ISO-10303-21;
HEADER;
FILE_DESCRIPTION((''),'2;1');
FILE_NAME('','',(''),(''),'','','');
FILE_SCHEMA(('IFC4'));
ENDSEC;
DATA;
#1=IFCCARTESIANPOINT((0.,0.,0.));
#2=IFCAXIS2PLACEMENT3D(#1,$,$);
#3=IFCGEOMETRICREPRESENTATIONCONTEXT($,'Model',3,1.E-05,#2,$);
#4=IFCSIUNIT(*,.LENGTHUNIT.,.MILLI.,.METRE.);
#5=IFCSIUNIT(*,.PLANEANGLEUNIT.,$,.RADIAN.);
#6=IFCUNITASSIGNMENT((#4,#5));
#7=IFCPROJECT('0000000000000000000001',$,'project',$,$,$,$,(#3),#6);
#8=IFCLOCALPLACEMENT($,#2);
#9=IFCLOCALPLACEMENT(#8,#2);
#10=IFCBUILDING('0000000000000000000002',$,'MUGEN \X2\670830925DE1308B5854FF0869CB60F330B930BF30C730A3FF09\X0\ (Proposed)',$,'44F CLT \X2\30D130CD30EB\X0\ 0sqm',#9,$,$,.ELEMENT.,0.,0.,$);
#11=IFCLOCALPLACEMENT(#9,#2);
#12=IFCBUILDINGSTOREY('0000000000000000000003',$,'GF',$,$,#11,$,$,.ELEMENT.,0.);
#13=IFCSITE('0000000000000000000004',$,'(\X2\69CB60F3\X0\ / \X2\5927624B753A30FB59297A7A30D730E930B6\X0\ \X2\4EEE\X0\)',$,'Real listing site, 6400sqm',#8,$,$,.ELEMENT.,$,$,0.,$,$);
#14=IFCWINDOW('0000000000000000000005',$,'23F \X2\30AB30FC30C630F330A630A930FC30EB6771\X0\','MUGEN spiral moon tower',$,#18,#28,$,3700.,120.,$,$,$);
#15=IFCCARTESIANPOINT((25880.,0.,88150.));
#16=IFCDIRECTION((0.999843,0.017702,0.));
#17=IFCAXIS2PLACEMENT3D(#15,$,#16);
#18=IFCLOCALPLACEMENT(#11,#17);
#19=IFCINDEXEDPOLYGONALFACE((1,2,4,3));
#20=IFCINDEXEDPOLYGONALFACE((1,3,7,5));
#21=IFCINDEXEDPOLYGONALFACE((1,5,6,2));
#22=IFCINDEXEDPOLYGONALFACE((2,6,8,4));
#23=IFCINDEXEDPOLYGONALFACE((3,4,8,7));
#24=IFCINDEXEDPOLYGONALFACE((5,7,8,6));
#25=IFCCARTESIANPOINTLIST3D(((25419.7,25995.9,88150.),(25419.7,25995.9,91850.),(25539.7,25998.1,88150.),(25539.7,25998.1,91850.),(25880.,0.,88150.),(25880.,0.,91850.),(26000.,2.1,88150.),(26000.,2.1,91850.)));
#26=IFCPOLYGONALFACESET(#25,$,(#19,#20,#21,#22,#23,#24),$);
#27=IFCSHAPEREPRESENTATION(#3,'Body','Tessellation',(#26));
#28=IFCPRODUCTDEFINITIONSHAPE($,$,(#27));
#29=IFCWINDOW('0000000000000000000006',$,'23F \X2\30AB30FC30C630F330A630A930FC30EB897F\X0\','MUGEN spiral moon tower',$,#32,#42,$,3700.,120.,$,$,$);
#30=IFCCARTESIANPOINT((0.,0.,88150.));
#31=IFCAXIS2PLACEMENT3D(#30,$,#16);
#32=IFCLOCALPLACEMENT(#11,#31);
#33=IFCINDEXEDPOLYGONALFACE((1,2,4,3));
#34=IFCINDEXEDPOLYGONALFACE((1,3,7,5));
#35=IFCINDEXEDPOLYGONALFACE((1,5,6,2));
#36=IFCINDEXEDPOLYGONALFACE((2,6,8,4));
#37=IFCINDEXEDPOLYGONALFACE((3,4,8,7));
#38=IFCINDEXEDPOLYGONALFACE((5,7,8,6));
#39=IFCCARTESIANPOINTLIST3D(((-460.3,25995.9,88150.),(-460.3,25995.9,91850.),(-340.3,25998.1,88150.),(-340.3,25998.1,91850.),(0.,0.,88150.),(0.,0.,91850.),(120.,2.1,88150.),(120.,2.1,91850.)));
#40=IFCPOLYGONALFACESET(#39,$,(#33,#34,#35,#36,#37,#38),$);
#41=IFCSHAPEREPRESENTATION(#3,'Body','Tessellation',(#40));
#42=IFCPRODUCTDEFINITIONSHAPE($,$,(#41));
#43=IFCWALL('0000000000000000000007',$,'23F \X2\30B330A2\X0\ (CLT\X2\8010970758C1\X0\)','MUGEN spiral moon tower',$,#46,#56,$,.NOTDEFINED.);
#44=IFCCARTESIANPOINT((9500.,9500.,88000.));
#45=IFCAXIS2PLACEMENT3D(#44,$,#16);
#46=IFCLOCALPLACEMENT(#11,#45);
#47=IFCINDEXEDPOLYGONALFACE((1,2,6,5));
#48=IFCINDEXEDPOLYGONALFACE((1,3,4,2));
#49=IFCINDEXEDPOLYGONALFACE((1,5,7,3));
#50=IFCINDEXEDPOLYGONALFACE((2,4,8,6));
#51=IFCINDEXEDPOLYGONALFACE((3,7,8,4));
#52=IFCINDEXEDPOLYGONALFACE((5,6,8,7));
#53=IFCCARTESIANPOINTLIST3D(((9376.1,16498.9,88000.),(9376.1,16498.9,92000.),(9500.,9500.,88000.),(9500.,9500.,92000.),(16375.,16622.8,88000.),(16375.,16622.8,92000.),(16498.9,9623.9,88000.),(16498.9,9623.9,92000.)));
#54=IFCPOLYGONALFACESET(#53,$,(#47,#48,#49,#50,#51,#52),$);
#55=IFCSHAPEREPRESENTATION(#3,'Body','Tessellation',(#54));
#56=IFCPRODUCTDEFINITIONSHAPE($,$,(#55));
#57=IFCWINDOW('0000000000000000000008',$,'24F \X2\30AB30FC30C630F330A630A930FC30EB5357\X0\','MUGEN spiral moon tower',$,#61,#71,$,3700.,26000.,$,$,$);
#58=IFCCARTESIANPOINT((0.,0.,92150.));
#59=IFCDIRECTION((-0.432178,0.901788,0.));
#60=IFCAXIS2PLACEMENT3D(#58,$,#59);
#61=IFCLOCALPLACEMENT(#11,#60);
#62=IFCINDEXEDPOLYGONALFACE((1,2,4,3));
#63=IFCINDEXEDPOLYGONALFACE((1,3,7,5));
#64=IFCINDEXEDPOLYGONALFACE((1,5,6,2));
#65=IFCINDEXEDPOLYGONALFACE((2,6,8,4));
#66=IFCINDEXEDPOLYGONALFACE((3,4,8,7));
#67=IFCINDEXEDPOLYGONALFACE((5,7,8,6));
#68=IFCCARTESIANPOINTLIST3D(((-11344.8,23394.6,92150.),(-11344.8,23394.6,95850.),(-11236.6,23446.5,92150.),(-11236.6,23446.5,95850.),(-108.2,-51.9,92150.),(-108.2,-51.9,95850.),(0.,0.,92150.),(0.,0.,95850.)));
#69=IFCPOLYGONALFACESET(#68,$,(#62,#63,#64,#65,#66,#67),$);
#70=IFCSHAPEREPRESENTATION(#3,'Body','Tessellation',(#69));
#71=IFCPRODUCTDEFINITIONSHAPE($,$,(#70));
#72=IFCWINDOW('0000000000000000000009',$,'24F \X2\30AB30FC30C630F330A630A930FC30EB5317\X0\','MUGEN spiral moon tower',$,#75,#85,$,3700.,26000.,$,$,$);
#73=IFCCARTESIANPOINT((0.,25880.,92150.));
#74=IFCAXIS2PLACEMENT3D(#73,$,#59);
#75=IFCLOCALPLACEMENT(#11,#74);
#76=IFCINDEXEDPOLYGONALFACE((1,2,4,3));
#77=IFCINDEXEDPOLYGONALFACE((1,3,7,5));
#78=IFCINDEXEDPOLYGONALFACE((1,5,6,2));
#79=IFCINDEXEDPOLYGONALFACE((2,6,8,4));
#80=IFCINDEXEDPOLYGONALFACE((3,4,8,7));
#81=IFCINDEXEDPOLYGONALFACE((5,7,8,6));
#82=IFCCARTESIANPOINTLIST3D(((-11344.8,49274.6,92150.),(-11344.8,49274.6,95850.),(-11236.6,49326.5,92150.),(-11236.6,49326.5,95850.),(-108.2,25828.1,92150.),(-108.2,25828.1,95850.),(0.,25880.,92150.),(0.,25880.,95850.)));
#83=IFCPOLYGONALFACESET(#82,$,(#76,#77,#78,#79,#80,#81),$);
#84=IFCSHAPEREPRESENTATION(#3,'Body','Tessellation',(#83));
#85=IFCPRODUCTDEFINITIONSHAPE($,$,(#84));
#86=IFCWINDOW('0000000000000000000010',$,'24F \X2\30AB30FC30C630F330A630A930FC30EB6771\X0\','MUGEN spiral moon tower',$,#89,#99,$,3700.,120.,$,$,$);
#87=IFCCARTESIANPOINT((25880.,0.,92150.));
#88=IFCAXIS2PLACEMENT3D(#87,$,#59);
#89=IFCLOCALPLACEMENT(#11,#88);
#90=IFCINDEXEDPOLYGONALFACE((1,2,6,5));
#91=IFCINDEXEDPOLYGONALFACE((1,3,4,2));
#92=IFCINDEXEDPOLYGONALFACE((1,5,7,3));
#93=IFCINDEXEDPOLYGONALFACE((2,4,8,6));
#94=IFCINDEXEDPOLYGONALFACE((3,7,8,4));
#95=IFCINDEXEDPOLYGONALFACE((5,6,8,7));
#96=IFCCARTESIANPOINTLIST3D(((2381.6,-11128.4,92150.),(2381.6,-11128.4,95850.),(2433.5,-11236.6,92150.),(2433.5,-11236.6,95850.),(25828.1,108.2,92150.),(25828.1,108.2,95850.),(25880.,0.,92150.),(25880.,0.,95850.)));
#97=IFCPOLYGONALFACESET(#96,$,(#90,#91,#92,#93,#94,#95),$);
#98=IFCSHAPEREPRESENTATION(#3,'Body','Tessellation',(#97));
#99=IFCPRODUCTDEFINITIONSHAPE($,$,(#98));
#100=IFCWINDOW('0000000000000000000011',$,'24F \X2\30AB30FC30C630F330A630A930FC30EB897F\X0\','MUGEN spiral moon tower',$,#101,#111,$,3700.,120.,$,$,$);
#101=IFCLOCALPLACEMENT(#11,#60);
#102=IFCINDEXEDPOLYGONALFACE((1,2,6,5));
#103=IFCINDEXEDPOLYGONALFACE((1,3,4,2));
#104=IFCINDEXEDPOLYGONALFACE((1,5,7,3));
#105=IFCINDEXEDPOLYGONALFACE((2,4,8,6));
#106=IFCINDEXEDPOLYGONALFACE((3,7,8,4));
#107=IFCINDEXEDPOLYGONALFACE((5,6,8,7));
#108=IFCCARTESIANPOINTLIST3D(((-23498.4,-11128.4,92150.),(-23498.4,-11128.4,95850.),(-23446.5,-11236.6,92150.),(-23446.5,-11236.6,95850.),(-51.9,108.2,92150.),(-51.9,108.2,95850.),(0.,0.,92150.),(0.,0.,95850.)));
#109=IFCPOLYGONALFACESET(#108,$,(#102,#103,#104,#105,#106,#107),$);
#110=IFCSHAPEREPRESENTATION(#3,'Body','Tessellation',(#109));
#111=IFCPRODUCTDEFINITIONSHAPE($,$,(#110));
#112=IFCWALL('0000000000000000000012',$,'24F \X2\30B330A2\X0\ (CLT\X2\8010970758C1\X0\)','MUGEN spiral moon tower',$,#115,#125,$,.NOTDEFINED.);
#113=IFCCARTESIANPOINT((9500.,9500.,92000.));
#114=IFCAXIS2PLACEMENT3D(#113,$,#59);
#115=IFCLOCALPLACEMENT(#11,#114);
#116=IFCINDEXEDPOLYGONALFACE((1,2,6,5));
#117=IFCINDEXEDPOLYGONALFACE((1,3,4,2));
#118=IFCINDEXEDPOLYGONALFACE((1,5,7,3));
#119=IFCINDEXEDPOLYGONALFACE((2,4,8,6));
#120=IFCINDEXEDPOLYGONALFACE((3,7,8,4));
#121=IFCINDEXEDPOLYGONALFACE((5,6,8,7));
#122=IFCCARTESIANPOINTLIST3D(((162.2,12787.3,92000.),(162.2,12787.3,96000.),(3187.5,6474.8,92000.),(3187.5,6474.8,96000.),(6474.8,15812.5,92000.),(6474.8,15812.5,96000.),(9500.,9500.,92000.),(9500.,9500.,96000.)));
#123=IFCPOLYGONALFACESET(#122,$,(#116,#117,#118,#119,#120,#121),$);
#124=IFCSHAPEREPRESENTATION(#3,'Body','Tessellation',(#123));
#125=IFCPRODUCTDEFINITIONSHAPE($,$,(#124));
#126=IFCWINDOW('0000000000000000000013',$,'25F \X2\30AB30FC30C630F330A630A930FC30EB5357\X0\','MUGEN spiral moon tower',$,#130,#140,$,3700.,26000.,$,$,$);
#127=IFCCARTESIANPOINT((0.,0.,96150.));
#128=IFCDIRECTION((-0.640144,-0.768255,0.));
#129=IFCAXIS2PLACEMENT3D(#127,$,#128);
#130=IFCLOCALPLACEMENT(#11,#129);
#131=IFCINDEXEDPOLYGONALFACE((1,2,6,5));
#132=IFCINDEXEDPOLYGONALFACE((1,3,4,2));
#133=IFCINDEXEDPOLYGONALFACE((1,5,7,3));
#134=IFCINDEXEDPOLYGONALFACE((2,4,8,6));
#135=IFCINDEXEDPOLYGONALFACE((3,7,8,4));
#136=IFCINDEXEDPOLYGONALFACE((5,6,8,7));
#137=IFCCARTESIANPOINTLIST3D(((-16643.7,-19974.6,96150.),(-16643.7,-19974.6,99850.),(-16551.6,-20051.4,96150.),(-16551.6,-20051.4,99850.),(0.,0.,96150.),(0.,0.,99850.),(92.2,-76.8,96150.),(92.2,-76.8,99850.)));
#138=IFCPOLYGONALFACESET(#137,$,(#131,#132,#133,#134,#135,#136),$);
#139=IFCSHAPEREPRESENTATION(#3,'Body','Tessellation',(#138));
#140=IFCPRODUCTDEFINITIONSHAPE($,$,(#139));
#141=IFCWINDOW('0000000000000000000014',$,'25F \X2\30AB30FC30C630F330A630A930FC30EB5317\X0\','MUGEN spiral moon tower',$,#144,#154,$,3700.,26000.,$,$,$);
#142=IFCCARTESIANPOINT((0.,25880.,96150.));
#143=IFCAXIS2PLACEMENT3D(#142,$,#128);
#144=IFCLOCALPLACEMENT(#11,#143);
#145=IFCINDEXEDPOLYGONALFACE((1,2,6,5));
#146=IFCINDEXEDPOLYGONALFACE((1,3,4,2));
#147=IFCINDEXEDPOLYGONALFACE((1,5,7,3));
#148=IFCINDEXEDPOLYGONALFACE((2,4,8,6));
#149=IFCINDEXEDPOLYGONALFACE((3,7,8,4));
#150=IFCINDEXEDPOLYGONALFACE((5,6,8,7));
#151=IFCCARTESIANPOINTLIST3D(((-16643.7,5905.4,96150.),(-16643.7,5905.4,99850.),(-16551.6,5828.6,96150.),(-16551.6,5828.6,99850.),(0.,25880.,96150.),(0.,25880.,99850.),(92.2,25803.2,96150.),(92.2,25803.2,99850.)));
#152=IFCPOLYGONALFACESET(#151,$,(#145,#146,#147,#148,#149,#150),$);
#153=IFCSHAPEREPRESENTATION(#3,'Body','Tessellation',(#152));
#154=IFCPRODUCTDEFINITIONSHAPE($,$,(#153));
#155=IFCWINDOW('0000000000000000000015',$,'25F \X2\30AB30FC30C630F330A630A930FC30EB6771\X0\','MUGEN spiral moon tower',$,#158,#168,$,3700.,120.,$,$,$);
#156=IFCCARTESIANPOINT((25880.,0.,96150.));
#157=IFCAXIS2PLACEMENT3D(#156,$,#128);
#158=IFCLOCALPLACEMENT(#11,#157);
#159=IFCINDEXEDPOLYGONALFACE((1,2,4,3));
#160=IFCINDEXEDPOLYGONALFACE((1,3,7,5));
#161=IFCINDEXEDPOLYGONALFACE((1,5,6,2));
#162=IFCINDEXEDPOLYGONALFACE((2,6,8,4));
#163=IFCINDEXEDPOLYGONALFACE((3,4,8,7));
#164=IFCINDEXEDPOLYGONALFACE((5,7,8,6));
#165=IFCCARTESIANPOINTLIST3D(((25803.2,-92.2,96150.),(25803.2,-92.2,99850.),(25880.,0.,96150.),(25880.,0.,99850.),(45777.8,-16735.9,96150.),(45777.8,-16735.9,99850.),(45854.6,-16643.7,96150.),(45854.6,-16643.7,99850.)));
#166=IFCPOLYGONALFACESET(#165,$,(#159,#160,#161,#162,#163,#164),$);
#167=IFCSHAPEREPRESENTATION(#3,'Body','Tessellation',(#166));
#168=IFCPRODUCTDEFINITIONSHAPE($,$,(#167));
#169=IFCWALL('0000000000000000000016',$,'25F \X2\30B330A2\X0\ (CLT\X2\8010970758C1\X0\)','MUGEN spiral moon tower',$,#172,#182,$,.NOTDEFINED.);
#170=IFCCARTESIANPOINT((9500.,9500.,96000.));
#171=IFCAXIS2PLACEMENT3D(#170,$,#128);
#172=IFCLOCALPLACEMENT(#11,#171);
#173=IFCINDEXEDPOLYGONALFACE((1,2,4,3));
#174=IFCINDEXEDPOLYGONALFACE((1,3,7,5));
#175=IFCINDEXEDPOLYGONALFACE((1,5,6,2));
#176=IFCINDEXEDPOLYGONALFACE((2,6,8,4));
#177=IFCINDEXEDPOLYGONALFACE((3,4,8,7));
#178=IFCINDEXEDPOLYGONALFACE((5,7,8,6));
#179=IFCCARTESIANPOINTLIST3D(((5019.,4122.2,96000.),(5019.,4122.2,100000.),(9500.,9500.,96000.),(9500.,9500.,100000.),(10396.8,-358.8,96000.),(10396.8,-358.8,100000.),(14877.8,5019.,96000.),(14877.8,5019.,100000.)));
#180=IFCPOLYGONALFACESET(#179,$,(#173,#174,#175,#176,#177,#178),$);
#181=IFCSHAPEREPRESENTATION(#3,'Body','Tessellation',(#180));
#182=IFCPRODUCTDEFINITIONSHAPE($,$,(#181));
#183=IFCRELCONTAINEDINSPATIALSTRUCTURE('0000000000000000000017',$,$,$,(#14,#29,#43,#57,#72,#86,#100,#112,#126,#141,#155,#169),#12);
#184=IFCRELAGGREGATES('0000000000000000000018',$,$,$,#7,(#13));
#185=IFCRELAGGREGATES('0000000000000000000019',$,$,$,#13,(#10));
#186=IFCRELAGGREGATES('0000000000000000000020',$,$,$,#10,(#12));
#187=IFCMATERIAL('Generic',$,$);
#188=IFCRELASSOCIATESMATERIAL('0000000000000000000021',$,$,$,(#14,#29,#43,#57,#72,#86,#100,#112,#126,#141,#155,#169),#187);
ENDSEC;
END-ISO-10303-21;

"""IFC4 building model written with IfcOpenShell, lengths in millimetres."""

from ifc_helpers import new_model, si_unit, frame, frame_2d, origin, place, context, project, spatial, rectangle, extrude, material, element, save


model = new_model("IFC4")

# Units and contexts
model_context = context("Model", 3, precision=1e-05, world=origin())
ifc_project = project(units=[si_unit("LENGTHUNIT", "METRE", prefix="MILLI"), si_unit("PLANEANGLEUNIT", "RADIAN")], contexts=[model_context])

# Site, building, storey
site_placement = place(None, origin())
site = spatial("IfcSite", under=ifc_project, at=site_placement, Name="(構想 / 大手町・天空プラザ 仮)", ObjectType="Real listing site, 6400sqm", CompositionType="ELEMENT", RefElevation=0.0)
building_placement = place(site_placement, origin())
building = spatial("IfcBuilding", under=site, at=building_placement, Name="MUGEN 月を巡る塔（構想スタディ） (Proposed)", ObjectType="44F CLT パネル 0sqm", CompositionType="ELEMENT", ElevationOfRefHeight=0.0, ElevationOfTerrain=0.0)
storey_placement = place(building_placement, origin())
storey = spatial("IfcBuildingStorey", under=building, at=storey_placement, Name="GF", CompositionType="ELEMENT", Elevation=0.0)

# Shared definitions
ifc_material = material(Name="Generic")

# Windows
window_1_placement = place(storey_placement, frame((25880.0, 0.0, 88150.0), x_axis=(0.999843, 0.017702, 0.0)))
element("IfcWindow", 1, at=window_1_placement, inside=storey, material=ifc_material, Name="23F カーテンウォール東", Description="MUGEN spiral moon tower", OverallHeight=3700.0, OverallWidth=120.0, context=model_context, shape_type="SweptSolid", body=[
    extrude(rectangle(XDim=120.0, YDim=26000.0, at=frame_2d((60.0, 13000.0))), frame((25880.0, 0.0, 88150.0), x_axis=(0.999843, 0.017702, 0.0)), (0.0, 0.0, 1.0), 3700.0),
])
window_2_placement = place(storey_placement, frame((0.0, 0.0, 88150.0), x_axis=(0.999843, 0.017702, 0.0)))
element("IfcWindow", 2, at=window_2_placement, inside=storey, material=ifc_material, Name="23F カーテンウォール西", Description="MUGEN spiral moon tower", OverallHeight=3700.0, OverallWidth=120.0, context=model_context, shape_type="SweptSolid", body=[
    extrude(rectangle(XDim=120.0, YDim=26000.0, at=frame_2d((60.0, 13000.0))), frame((0.0, 0.0, 88150.0), x_axis=(0.999843, 0.017702, 0.0)), (0.0, 0.0, 1.0), 3700.0),
])

# Wall
wall_1_placement = place(storey_placement, frame((9500.0, 9500.0, 88000.0), x_axis=(0.999843, 0.017702, 0.0)))
element("IfcWall", 3, at=wall_1_placement, inside=storey, material=ifc_material, Name="23F コア (CLT耐震壁)", Description="MUGEN spiral moon tower", PredefinedType="NOTDEFINED", context=model_context, shape_type="SweptSolid", body=[
    extrude(rectangle(XDim=7000.0, YDim=7000.0, at=frame_2d((3500.0, 3500.0))), frame((9500.0, 9500.0, 88000.0), x_axis=(0.999843, 0.017702, 0.0)), (0.0, 0.0, 1.0), 4000.0),
])

# Windows
window_3_placement = place(storey_placement, frame((0.0, 0.0, 92150.0), x_axis=(-0.432178, 0.901788, 0.0)))
element("IfcWindow", 4, at=window_3_placement, inside=storey, material=ifc_material, Name="24F カーテンウォール南", Description="MUGEN spiral moon tower", OverallHeight=3700.0, OverallWidth=26000.0, context=model_context, shape_type="SweptSolid", body=[
    extrude(rectangle(XDim=26000.0, YDim=120.0, at=frame_2d((13000.0, 60.0))), frame((0.0, 0.0, 92150.0), x_axis=(-0.432178, 0.901788, 0.0)), (0.0, 0.0, 1.0), 3700.0),
])
window_4_placement = place(storey_placement, frame((0.0, 25880.0, 92150.0), x_axis=(-0.432178, 0.901788, 0.0)))
element("IfcWindow", 5, at=window_4_placement, inside=storey, material=ifc_material, Name="24F カーテンウォール北", Description="MUGEN spiral moon tower", OverallHeight=3700.0, OverallWidth=26000.0, context=model_context, shape_type="SweptSolid", body=[
    extrude(rectangle(XDim=26000.0, YDim=120.0, at=frame_2d((13000.0, 60.0))), frame((0.0, 25880.0, 92150.0), x_axis=(-0.432178, 0.901788, 0.0)), (0.0, 0.0, 1.0), 3700.0),
])
window_5_placement = place(storey_placement, frame((25880.0, 0.0, 92150.0), x_axis=(-0.432178, 0.901788, 0.0)))
element("IfcWindow", 6, at=window_5_placement, inside=storey, material=ifc_material, Name="24F カーテンウォール東", Description="MUGEN spiral moon tower", OverallHeight=3700.0, OverallWidth=120.0, context=model_context, shape_type="SweptSolid", body=[
    extrude(rectangle(XDim=120.0, YDim=26000.0, at=frame_2d((60.0, 13000.0))), frame((25880.0, 0.0, 92150.0), x_axis=(-0.432178, 0.901788, 0.0)), (0.0, 0.0, 1.0), 3700.0),
])
window_6_placement = place(storey_placement, frame((0.0, 0.0, 92150.0), x_axis=(-0.432178, 0.901788, 0.0)))
element("IfcWindow", 7, at=window_6_placement, inside=storey, material=ifc_material, Name="24F カーテンウォール西", Description="MUGEN spiral moon tower", OverallHeight=3700.0, OverallWidth=120.0, context=model_context, shape_type="SweptSolid", body=[
    extrude(rectangle(XDim=120.0, YDim=26000.0, at=frame_2d((60.0, 13000.0))), frame((0.0, 0.0, 92150.0), x_axis=(-0.432178, 0.901788, 0.0)), (0.0, 0.0, 1.0), 3700.0),
])

# Wall
wall_2_placement = place(storey_placement, frame((9500.0, 9500.0, 92000.0), x_axis=(-0.432178, 0.901788, 0.0)))
element("IfcWall", 8, at=wall_2_placement, inside=storey, material=ifc_material, Name="24F コア (CLT耐震壁)", Description="MUGEN spiral moon tower", PredefinedType="NOTDEFINED", context=model_context, shape_type="SweptSolid", body=[
    extrude(rectangle(XDim=7000.0, YDim=7000.0, at=frame_2d((3500.0, 3500.0))), frame((9500.0, 9500.0, 92000.0), x_axis=(-0.432178, 0.901788, 0.0)), (0.0, 0.0, 1.0), 4000.0),
])

# Windows
window_7_placement = place(storey_placement, frame((0.0, 0.0, 96150.0), x_axis=(-0.640144, -0.768255, 0.0)))
element("IfcWindow", 9, at=window_7_placement, inside=storey, material=ifc_material, Name="25F カーテンウォール南", Description="MUGEN spiral moon tower", OverallHeight=3700.0, OverallWidth=26000.0, context=model_context, shape_type="SweptSolid", body=[
    extrude(rectangle(XDim=26000.0, YDim=120.0, at=frame_2d((13000.0, 60.0))), frame((0.0, 0.0, 96150.0), x_axis=(-0.640144, -0.768255, 0.0)), (0.0, 0.0, 1.0), 3700.0),
])
window_8_placement = place(storey_placement, frame((0.0, 25880.0, 96150.0), x_axis=(-0.640144, -0.768255, 0.0)))
element("IfcWindow", 10, at=window_8_placement, inside=storey, material=ifc_material, Name="25F カーテンウォール北", Description="MUGEN spiral moon tower", OverallHeight=3700.0, OverallWidth=26000.0, context=model_context, shape_type="SweptSolid", body=[
    extrude(rectangle(XDim=26000.0, YDim=120.0, at=frame_2d((13000.0, 60.0))), frame((0.0, 25880.0, 96150.0), x_axis=(-0.640144, -0.768255, 0.0)), (0.0, 0.0, 1.0), 3700.0),
])
window_9_placement = place(storey_placement, frame((25880.0, 0.0, 96150.0), x_axis=(-0.640144, -0.768255, 0.0)))
element("IfcWindow", 11, at=window_9_placement, inside=storey, material=ifc_material, Name="25F カーテンウォール東", Description="MUGEN spiral moon tower", OverallHeight=3700.0, OverallWidth=120.0, context=model_context, shape_type="SweptSolid", body=[
    extrude(rectangle(XDim=120.0, YDim=26000.0, at=frame_2d((60.0, 13000.0))), frame((25880.0, 0.0, 96150.0), x_axis=(-0.640144, -0.768255, 0.0)), (0.0, 0.0, 1.0), 3700.0),
])

# Wall
wall_3_placement = place(storey_placement, frame((9500.0, 9500.0, 96000.0), x_axis=(-0.640144, -0.768255, 0.0)))
element("IfcWall", 12, at=wall_3_placement, inside=storey, material=ifc_material, Name="25F コア (CLT耐震壁)", Description="MUGEN spiral moon tower", PredefinedType="NOTDEFINED", context=model_context, shape_type="SweptSolid", body=[
    extrude(rectangle(XDim=7000.0, YDim=7000.0, at=frame_2d((3500.0, 3500.0))), frame((9500.0, 9500.0, 96000.0), x_axis=(-0.640144, -0.768255, 0.0)), (0.0, 0.0, 1.0), 4000.0),
])

save(model, "model.ifc")
